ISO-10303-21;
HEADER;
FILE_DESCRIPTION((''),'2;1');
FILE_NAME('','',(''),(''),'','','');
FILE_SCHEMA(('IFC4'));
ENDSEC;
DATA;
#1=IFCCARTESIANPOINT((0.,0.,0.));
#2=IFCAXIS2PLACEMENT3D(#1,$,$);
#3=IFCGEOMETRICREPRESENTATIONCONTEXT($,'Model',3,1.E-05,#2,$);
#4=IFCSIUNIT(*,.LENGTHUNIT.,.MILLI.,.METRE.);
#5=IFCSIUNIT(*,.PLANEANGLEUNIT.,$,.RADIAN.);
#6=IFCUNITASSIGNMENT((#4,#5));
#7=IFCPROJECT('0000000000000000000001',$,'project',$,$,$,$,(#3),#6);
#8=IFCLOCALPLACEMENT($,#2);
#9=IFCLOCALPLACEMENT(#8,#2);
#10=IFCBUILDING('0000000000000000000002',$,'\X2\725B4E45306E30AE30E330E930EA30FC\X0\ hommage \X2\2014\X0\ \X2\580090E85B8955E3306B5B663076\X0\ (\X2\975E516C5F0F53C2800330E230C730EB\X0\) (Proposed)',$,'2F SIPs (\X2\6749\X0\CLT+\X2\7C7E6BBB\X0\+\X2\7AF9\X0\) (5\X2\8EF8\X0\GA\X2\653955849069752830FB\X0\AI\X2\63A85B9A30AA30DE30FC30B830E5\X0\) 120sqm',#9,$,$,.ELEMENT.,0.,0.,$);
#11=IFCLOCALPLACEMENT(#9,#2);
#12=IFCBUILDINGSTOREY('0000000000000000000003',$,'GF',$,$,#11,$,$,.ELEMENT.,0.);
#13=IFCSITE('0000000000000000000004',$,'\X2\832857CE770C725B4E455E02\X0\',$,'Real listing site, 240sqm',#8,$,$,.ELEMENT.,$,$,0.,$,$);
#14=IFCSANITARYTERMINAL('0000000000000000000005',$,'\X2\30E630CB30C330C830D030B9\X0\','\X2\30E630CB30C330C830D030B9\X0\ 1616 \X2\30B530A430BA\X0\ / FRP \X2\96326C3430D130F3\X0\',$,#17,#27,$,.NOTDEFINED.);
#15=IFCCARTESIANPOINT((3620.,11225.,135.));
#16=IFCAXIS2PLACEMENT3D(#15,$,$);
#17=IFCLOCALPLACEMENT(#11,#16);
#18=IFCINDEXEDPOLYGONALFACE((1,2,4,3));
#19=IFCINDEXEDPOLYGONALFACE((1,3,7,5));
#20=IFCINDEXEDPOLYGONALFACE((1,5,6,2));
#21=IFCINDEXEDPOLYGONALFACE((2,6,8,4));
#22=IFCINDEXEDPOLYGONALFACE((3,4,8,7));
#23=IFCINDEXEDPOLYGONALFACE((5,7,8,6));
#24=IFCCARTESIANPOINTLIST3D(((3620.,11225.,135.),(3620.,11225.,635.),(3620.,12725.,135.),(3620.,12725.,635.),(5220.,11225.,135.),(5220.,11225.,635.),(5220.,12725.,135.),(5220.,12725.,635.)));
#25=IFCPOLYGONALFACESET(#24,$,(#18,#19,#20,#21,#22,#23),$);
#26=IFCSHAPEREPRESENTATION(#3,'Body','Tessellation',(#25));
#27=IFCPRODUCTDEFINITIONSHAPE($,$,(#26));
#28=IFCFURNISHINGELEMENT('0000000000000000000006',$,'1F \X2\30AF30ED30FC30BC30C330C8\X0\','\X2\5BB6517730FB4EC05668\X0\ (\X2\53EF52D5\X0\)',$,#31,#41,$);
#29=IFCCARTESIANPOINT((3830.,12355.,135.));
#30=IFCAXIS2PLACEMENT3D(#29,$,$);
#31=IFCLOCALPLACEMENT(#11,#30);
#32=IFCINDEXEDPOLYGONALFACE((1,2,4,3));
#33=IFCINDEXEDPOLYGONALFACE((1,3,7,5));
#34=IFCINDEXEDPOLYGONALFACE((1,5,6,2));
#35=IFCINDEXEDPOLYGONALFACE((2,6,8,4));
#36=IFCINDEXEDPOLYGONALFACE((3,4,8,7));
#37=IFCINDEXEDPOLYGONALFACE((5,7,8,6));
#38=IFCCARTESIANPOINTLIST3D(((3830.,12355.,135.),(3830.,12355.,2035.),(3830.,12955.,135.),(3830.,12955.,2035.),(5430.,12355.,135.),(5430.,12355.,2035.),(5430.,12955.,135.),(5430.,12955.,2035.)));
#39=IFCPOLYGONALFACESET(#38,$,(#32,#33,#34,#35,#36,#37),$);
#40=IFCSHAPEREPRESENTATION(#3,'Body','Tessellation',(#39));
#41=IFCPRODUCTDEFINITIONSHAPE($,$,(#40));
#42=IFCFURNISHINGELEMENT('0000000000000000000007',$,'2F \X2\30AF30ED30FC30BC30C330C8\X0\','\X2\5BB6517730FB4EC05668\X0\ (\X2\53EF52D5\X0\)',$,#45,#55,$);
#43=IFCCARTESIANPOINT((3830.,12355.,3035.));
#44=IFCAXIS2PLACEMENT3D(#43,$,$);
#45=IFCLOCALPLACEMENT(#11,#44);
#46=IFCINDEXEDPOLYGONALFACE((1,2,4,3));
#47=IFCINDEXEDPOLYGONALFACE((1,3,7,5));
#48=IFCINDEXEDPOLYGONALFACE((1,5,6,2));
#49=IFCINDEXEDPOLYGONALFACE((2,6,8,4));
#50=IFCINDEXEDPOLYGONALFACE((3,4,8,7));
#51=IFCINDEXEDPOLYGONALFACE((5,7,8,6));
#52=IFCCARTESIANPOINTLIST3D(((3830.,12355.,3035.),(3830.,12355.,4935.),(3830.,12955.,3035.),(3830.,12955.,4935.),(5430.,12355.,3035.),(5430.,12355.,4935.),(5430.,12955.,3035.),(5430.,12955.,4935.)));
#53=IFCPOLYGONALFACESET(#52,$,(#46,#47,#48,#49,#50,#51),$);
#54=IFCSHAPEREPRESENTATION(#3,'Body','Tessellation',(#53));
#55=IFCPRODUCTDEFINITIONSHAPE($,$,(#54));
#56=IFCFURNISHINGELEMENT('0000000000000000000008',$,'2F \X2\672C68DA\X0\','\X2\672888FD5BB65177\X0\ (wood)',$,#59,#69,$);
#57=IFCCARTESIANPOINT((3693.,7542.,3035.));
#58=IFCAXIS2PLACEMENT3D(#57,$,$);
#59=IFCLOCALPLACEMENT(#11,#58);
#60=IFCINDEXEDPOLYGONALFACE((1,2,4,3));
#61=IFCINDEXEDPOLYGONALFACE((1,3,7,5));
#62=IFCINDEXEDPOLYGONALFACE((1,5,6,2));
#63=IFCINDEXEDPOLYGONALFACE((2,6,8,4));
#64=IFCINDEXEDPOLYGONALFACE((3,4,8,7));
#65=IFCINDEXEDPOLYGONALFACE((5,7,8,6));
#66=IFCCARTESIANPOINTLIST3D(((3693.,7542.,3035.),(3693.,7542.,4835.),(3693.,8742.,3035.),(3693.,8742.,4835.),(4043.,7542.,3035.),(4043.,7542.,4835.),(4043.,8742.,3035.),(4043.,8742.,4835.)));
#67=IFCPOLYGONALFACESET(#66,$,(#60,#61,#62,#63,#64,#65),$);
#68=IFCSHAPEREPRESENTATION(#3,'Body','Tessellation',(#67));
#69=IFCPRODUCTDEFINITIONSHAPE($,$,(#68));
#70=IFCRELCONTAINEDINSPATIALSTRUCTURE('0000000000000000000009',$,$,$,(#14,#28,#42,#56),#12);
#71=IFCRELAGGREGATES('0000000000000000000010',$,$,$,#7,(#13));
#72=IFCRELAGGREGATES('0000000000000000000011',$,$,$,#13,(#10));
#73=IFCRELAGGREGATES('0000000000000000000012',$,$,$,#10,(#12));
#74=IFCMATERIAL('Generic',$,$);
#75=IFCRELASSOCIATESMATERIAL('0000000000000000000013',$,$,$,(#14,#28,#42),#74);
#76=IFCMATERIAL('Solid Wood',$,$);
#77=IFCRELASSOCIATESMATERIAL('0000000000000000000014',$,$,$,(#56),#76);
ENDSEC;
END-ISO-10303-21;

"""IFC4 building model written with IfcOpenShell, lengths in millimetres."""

from ifc_helpers import new_model, si_unit, frame, frame_2d, origin, place, context, project, spatial, rectangle, extrude, material, element, save


model = new_model("IFC4")

# Units and contexts
model_context = context("Model", 3, precision=1e-05, world=origin())
ifc_project = project(units=[si_unit("LENGTHUNIT", "METRE", prefix="MILLI"), si_unit("PLANEANGLEUNIT", "RADIAN")], contexts=[model_context])

# Site, building, storey
site_placement = place(None, origin())
site = spatial("IfcSite", under=ifc_project, at=site_placement, Name="茨城県牛久市", ObjectType="Real listing site, 240sqm", CompositionType="ELEMENT", RefElevation=0.0)
building_placement = place(site_placement, origin())
building = spatial("IfcBuilding", under=site, at=building_placement, Name="牛久のギャラリー hommage — 堀部安嗣に学ぶ (非公式参考モデル) (Proposed)", ObjectType="2F SIPs (杉CLT+籾殻+竹) (5軸GA改善適用・AI推定オマージュ) 120sqm", CompositionType="ELEMENT", ElevationOfRefHeight=0.0, ElevationOfTerrain=0.0)
storey_placement = place(building_placement, origin())
storey = spatial("IfcBuildingStorey", under=building, at=storey_placement, Name="GF", CompositionType="ELEMENT", Elevation=0.0)

# Shared definitions
ifc_material_1 = material(Name="Solid Wood")

# Shared definitions
ifc_material_2 = material(Name="Generic")

# Sanitary terminal
sanitary_terminal_placement = place(storey_placement, frame((3620.0, 11225.0, 135.0)))
element("IfcSanitaryTerminal", 1, at=sanitary_terminal_placement, inside=storey, material=ifc_material_2, Name="ユニットバス", Description="ユニットバス 1616 サイズ / FRP 防水パン", PredefinedType="NOTDEFINED", context=model_context, shape_type="SweptSolid", body=[
    extrude(rectangle(XDim=1600.0, YDim=1500.0, at=frame_2d((800.0, 750.0))), frame((3620.0, 11225.0, 135.0)), (0.0, 0.0, 1.0), 500.0),
])

# Furnishing elements
furnishing_1_placement = place(storey_placement, frame((3830.0, 12355.0, 135.0)))
element("IfcFurnishingElement", 2, at=furnishing_1_placement, inside=storey, material=ifc_material_2, Name="1F クローゼット", Description="家具・什器 (可動)", context=model_context, shape_type="SweptSolid", body=[
    extrude(rectangle(XDim=1600.0, YDim=600.0, at=frame_2d((800.0, 300.0))), frame((3830.0, 12355.0, 135.0)), (0.0, 0.0, 1.0), 1900.0),
])
furnishing_2_placement = place(storey_placement, frame((3830.0, 12355.0, 3035.0)))
element("IfcFurnishingElement", 3, at=furnishing_2_placement, inside=storey, material=ifc_material_2, Name="2F クローゼット", Description="家具・什器 (可動)", context=model_context, shape_type="SweptSolid", body=[
    extrude(rectangle(XDim=1600.0, YDim=600.0, at=frame_2d((800.0, 300.0))), frame((3830.0, 12355.0, 3035.0)), (0.0, 0.0, 1.0), 1900.0),
])
furnishing_3_placement = place(storey_placement, frame((3693.0, 7542.0, 3035.0)))
element("IfcFurnishingElement", 4, at=furnishing_3_placement, inside=storey, material=ifc_material_1, Name="2F 本棚", Description="木製家具 (wood)", context=model_context, shape_type="SweptSolid", body=[
    extrude(rectangle(XDim=350.0, YDim=1200.0, at=frame_2d((175.0, 600.0))), frame((3693.0, 7542.0, 3035.0)), (0.0, 0.0, 1.0), 1800.0),
])

save(model, "model.ifc")
